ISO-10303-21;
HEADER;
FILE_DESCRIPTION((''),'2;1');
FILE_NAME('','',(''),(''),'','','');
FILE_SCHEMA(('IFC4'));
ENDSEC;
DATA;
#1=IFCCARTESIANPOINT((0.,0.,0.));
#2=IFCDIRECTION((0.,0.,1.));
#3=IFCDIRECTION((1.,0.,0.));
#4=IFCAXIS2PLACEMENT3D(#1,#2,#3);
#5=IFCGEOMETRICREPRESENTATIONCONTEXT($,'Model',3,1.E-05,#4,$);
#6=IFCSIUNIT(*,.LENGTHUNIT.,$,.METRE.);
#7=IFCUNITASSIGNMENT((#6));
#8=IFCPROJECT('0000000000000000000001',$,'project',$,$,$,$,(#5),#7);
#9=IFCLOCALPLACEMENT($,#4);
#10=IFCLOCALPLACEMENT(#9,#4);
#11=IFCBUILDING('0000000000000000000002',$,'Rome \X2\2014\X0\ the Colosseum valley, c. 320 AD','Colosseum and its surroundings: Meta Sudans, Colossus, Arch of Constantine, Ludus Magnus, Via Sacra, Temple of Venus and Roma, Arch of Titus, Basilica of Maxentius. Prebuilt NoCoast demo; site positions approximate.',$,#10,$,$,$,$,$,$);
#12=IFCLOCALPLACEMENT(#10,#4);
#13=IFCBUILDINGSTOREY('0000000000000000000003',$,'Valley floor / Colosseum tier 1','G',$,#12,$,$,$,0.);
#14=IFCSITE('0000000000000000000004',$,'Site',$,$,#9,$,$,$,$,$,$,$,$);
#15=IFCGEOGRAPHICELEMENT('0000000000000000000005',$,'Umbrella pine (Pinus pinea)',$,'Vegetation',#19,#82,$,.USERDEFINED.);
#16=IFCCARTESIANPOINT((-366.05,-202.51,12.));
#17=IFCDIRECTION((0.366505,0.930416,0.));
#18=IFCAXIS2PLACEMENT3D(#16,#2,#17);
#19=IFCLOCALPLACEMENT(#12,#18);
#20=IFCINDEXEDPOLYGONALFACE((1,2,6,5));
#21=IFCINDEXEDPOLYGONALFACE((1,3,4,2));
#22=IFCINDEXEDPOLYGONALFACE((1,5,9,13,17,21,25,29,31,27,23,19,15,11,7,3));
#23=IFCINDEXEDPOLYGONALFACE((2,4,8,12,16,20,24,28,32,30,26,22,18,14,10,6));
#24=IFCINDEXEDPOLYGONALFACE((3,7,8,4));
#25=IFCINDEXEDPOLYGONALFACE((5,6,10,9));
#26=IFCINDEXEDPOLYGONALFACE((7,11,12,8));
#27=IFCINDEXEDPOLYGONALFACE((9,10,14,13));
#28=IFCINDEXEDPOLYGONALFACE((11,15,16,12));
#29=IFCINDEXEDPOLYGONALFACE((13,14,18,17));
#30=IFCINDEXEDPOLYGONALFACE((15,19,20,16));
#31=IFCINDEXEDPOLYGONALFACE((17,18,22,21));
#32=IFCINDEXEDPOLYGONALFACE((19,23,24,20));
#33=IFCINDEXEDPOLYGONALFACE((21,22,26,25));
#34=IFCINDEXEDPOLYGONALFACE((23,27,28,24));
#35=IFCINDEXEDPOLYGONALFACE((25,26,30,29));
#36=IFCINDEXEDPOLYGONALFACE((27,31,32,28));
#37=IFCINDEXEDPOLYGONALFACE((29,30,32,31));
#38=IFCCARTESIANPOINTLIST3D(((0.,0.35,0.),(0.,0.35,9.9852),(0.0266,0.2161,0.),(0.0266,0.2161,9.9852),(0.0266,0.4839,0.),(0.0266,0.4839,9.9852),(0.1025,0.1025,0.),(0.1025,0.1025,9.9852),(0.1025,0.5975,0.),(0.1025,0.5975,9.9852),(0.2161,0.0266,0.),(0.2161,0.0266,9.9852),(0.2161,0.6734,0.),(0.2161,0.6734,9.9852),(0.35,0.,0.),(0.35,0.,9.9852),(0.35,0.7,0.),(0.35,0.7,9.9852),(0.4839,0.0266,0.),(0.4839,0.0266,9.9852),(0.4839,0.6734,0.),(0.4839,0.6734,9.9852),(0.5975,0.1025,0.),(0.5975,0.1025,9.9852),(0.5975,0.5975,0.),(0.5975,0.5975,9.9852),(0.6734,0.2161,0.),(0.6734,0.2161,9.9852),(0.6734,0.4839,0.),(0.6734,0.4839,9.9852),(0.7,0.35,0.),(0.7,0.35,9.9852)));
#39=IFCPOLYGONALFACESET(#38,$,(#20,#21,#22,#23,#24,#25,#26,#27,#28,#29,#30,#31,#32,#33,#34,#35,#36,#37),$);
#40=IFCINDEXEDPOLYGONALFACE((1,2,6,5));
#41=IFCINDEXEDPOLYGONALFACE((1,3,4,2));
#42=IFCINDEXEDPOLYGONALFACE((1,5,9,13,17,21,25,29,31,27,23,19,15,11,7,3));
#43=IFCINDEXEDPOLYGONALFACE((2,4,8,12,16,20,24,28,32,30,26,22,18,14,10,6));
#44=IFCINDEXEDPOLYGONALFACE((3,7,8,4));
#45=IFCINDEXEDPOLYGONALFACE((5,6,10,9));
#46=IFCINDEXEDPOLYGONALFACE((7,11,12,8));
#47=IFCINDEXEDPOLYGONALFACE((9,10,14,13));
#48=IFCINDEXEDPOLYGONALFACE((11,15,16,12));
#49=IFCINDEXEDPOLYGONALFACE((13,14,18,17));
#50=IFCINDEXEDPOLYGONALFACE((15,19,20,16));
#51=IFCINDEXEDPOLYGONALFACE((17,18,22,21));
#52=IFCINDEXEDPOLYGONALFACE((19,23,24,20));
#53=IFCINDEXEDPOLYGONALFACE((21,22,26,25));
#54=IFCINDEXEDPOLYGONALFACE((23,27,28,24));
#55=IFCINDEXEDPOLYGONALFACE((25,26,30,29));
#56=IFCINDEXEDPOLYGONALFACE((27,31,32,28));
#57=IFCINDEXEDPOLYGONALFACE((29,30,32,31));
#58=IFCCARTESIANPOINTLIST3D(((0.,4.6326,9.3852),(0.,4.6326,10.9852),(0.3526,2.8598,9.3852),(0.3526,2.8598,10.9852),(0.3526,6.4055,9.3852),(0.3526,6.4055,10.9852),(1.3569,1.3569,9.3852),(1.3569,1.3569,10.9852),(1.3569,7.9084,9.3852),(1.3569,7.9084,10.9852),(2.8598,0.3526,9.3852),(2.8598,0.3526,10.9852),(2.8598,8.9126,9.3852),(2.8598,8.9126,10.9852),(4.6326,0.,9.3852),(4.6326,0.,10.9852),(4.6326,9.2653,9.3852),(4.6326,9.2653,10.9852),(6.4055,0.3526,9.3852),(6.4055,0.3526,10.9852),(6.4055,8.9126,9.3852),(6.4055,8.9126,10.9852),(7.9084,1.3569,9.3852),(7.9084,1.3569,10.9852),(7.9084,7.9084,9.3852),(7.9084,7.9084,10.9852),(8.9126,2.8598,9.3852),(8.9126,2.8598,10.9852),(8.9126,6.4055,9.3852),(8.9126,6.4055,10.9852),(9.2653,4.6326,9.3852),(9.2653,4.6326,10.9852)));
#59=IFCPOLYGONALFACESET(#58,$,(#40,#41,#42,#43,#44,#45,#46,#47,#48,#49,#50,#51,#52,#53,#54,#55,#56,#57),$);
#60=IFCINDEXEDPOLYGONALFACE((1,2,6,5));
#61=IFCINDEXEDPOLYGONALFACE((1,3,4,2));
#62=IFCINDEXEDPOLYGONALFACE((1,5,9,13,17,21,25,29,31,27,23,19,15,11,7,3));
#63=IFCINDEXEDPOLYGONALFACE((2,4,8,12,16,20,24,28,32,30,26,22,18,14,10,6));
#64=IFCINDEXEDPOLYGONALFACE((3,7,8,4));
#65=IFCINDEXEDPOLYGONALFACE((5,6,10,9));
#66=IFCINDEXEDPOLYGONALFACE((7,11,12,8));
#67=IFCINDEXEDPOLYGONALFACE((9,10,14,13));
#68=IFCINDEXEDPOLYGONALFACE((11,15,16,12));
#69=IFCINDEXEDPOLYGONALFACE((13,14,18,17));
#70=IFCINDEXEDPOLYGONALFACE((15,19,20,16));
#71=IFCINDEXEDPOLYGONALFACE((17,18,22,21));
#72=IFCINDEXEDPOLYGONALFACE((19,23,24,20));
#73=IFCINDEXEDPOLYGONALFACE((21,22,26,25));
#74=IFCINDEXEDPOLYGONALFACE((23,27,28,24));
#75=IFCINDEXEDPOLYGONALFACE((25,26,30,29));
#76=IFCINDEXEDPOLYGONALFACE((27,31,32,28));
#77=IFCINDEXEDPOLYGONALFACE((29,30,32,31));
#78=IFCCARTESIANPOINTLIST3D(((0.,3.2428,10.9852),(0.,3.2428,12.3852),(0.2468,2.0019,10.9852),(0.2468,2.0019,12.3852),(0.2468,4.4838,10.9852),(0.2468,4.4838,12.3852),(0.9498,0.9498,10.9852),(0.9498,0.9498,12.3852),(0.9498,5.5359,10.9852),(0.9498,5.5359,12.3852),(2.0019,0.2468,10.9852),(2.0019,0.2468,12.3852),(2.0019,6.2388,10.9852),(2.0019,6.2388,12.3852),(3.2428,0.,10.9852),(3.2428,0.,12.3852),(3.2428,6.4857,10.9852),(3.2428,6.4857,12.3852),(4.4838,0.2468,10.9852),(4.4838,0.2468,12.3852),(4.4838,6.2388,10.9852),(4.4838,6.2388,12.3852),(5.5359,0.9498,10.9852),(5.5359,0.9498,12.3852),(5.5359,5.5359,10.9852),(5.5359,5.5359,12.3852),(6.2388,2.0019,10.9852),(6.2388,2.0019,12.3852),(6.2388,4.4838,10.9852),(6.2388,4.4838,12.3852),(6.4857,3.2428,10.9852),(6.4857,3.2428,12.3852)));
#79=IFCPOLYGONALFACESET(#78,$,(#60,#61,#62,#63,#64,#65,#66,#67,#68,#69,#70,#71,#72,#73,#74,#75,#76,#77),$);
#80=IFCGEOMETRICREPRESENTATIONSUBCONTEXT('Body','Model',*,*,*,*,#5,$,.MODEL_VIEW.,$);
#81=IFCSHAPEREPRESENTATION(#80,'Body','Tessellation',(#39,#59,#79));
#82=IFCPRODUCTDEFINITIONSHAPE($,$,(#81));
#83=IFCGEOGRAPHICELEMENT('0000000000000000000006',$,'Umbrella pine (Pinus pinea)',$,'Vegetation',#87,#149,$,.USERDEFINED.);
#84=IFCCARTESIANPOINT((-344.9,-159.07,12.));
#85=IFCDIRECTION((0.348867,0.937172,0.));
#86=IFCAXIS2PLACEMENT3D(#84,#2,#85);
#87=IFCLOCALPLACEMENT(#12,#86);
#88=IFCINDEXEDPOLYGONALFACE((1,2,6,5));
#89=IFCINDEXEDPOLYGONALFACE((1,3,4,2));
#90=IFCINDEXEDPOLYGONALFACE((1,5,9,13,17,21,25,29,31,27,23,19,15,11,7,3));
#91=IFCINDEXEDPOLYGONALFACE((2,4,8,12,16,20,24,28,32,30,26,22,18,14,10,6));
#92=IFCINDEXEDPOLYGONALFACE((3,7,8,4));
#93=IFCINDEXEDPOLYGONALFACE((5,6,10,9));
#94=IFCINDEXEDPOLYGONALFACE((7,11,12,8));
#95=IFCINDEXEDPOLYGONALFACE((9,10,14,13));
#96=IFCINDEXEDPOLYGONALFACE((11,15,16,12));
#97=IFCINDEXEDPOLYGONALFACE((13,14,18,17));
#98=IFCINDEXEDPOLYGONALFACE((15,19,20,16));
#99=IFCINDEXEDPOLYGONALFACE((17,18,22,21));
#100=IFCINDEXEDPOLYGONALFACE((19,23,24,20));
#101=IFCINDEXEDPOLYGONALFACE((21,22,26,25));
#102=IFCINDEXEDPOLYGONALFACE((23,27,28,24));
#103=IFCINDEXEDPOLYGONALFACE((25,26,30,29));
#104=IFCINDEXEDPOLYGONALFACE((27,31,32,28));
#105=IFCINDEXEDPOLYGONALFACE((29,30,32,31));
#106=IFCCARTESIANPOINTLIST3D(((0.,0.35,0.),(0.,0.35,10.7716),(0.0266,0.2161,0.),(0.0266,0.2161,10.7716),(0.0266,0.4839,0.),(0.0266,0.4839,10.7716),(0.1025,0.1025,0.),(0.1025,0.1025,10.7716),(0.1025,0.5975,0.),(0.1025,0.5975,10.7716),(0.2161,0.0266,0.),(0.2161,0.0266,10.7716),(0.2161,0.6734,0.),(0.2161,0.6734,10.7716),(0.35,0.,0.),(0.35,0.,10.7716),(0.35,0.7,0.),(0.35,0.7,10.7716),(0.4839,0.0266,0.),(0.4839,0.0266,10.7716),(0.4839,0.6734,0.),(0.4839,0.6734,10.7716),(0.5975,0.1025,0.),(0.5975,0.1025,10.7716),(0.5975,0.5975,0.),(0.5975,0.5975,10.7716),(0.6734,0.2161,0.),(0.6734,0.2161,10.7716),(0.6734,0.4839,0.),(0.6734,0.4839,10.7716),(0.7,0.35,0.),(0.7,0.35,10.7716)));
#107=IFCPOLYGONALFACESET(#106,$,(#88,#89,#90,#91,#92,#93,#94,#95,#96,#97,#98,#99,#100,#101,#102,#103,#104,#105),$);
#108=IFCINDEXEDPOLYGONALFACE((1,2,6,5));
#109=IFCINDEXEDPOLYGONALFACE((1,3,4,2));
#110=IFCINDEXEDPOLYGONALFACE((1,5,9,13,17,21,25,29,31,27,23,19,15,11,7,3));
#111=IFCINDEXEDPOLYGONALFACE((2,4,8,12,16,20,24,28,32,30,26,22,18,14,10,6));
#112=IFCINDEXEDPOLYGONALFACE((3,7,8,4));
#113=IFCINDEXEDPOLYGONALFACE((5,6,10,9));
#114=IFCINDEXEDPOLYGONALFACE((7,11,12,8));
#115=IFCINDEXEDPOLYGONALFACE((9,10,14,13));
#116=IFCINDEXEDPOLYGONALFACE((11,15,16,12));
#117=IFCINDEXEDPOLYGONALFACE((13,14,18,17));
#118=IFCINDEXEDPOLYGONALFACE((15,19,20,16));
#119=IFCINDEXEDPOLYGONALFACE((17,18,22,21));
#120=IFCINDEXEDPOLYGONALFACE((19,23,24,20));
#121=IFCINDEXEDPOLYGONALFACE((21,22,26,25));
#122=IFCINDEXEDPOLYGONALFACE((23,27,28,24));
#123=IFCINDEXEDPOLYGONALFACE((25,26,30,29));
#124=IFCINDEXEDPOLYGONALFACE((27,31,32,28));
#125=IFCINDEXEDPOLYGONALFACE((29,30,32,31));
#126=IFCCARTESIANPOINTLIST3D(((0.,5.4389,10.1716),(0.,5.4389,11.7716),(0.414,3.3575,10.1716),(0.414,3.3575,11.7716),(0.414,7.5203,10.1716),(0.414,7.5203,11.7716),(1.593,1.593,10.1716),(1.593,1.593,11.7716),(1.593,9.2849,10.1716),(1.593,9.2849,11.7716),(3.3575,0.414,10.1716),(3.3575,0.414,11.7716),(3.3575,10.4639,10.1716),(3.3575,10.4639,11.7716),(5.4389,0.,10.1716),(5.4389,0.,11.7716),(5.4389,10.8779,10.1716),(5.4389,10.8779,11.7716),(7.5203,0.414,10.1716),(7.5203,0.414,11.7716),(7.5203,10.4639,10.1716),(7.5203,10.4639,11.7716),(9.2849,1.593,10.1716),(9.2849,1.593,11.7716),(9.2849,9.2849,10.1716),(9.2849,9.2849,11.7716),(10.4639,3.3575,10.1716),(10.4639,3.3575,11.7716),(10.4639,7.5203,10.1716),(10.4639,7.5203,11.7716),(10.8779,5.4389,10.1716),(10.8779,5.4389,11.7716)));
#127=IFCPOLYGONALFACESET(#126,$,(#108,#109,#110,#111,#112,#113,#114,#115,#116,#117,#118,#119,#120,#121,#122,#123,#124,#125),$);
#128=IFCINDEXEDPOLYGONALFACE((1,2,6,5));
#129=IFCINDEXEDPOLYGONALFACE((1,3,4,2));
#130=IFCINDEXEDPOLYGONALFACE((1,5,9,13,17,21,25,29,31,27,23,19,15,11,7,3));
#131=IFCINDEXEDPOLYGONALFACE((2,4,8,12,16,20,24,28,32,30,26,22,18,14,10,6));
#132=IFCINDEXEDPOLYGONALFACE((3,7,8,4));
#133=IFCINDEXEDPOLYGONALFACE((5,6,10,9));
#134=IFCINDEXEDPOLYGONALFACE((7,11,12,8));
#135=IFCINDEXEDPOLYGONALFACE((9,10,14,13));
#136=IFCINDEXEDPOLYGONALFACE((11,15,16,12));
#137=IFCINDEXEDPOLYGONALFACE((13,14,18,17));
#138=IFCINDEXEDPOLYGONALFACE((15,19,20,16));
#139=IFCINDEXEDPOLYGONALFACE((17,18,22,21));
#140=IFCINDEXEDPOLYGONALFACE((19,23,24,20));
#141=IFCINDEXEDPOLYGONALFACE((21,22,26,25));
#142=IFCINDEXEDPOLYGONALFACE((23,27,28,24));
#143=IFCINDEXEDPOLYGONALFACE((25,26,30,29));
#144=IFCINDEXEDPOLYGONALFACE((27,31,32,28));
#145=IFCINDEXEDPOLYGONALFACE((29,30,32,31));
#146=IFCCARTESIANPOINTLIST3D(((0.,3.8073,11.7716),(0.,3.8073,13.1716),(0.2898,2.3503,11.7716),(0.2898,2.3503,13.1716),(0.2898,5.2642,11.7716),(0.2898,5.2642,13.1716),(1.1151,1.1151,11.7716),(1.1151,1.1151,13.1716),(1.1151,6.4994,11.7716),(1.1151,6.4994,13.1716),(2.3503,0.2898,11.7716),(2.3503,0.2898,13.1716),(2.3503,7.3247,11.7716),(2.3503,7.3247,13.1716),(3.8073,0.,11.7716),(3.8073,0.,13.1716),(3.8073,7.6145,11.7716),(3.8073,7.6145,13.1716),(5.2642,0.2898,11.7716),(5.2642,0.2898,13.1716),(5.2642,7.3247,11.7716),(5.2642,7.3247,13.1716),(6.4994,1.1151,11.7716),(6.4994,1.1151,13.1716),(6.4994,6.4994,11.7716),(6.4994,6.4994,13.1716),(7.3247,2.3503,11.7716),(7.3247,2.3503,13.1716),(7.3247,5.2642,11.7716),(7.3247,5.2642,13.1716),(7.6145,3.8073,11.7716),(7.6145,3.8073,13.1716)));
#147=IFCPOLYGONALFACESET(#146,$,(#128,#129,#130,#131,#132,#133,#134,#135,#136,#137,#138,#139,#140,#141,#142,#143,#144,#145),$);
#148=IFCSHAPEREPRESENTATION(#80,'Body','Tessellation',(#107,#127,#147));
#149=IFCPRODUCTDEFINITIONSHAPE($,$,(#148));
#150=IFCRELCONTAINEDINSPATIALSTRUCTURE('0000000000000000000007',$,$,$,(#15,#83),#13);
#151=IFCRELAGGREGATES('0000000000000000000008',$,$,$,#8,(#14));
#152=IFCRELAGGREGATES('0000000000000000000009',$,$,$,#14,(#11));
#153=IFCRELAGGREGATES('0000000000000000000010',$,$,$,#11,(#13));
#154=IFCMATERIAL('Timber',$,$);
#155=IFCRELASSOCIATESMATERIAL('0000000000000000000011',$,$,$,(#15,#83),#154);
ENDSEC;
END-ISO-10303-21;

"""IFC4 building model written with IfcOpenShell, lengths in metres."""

from ifc_helpers import new_model, si_unit, frame, origin_with_axes, place, context, subcontext, project, spatial, polyline, outline, extrude, material, element, save


model = new_model("IFC4")

# Units and contexts
model_context = context("Model", 3, precision=1e-05, world=origin_with_axes())
body_context = subcontext(model_context, "Body", "Model", "MODEL_VIEW")
ifc_project = project(units=[si_unit("LENGTHUNIT", "METRE")], contexts=[model_context])

# Site, building, storey
site_placement = place(None, origin_with_axes())
site = spatial("IfcSite", under=ifc_project, at=site_placement, Name="Site")
building_placement = place(site_placement, origin_with_axes())
building = spatial("IfcBuilding", under=site, at=building_placement, Name="Rome — the Colosseum valley, c. 320 AD", Description="Colosseum and its surroundings: Meta Sudans, Colossus, Arch of Constantine, Ludus Magnus, Via Sacra, Temple of Venus and Roma, Arch of Titus, Basilica of Maxentius. Prebuilt NoCoast demo; site positions approximate.")
storey_placement = place(building_placement, origin_with_axes())
storey = spatial("IfcBuildingStorey", under=building, at=storey_placement, Name="Valley floor / Colosseum tier 1", Description="G", Elevation=0.0)

# Shared definitions
ifc_material_1 = material(Name="Timber")

# Geographic elements
geographic_element_1_placement = place(storey_placement, frame((-366.05, -202.51, 12.0), z_axis=(0.0, 0.0, 1.0), x_axis=(0.366505, 0.930416, 0.0)))
element("IfcGeographicElement", 1, at=geographic_element_1_placement, inside=storey, material=ifc_material_1, Name="Umbrella pine (Pinus pinea)", ObjectType="Vegetation", PredefinedType="USERDEFINED", context=body_context, shape_type="SweptSolid", body=[
    extrude(outline(polyline([(0.7, 0.35), (0.6734, 0.4839), (0.5975, 0.5975), (0.4839, 0.6734), (0.35, 0.7), (0.2161, 0.6734), (0.1025, 0.5975), (0.0266, 0.4839), (0.0, 0.35), (0.0266, 0.2161), (0.1025, 0.1025), (0.2161, 0.0266), (0.35, 0.0), (0.4839, 0.0266), (0.5975, 0.1025), (0.6734, 0.2161), (0.7, 0.35)])), origin_with_axes(), (0.0, 0.0, 1.0), 9.9852),
    extrude(outline(polyline([(9.2653, 4.6326), (8.9126, 6.4055), (7.9084, 7.9084), (6.4055, 8.9126), (4.6326, 9.2653), (2.8598, 8.9126), (1.3569, 7.9084), (0.3526, 6.4055), (0.0, 4.6326), (0.3526, 2.8598), (1.3569, 1.3569), (2.8598, 0.3526), (4.6326, 0.0), (6.4055, 0.3526), (7.9084, 1.3569), (8.9126, 2.8598), (9.2653, 4.6326)])), frame((0.0, 0.0, 9.3852), z_axis=(0.0, 0.0, 1.0), x_axis=(1.0, 0.0, 0.0)), (0.0, 0.0, 1.0), 1.6),
    extrude(outline(polyline([(6.4857, 3.2428), (6.2388, 4.4838), (5.5359, 5.5359), (4.4838, 6.2388), (3.2428, 6.4857), (2.0019, 6.2388), (0.9498, 5.5359), (0.2468, 4.4838), (0.0, 3.2428), (0.2468, 2.0019), (0.9498, 0.9498), (2.0019, 0.2468), (3.2428, 0.0), (4.4838, 0.2468), (5.5359, 0.9498), (6.2388, 2.0019), (6.4857, 3.2428)])), frame((0.0, 0.0, 10.9852), z_axis=(0.0, 0.0, 1.0), x_axis=(1.0, 0.0, 0.0)), (0.0, 0.0, 1.0), 1.4),
])
geographic_element_2_placement = place(storey_placement, frame((-344.9, -159.07, 12.0), z_axis=(0.0, 0.0, 1.0), x_axis=(0.348867, 0.937172, 0.0)))
element("IfcGeographicElement", 2, at=geographic_element_2_placement, inside=storey, material=ifc_material_1, Name="Umbrella pine (Pinus pinea)", ObjectType="Vegetation", PredefinedType="USERDEFINED", context=body_context, shape_type="SweptSolid", body=[
    extrude(outline(polyline([(0.7, 0.35), (0.6734, 0.4839), (0.5975, 0.5975), (0.4839, 0.6734), (0.35, 0.7), (0.2161, 0.6734), (0.1025, 0.5975), (0.0266, 0.4839), (0.0, 0.35), (0.0266, 0.2161), (0.1025, 0.1025), (0.2161, 0.0266), (0.35, 0.0), (0.4839, 0.0266), (0.5975, 0.1025), (0.6734, 0.2161), (0.7, 0.35)])), origin_with_axes(), (0.0, 0.0, 1.0), 10.7716),
    extrude(outline(polyline([(10.8779, 5.4389), (10.4639, 7.5203), (9.2849, 9.2849), (7.5203, 10.4639), (5.4389, 10.8779), (3.3575, 10.4639), (1.593, 9.2849), (0.414, 7.5203), (0.0, 5.4389), (0.414, 3.3575), (1.593, 1.593), (3.3575, 0.414), (5.4389, 0.0), (7.5203, 0.414), (9.2849, 1.593), (10.4639, 3.3575), (10.8779, 5.4389)])), frame((0.0, 0.0, 10.1716), z_axis=(0.0, 0.0, 1.0), x_axis=(1.0, 0.0, 0.0)), (0.0, 0.0, 1.0), 1.6),
    extrude(outline(polyline([(7.6145, 3.8073), (7.3247, 5.2642), (6.4994, 6.4994), (5.2642, 7.3247), (3.8073, 7.6145), (2.3503, 7.3247), (1.1151, 6.4994), (0.2898, 5.2642), (0.0, 3.8073), (0.2898, 2.3503), (1.1151, 1.1151), (2.3503, 0.2898), (3.8073, 0.0), (5.2642, 0.2898), (6.4994, 1.1151), (7.3247, 2.3503), (7.6145, 3.8073)])), frame((0.0, 0.0, 11.7716), z_axis=(0.0, 0.0, 1.0), x_axis=(1.0, 0.0, 0.0)), (0.0, 0.0, 1.0), 1.4),
])

save(model, "model.ifc")
